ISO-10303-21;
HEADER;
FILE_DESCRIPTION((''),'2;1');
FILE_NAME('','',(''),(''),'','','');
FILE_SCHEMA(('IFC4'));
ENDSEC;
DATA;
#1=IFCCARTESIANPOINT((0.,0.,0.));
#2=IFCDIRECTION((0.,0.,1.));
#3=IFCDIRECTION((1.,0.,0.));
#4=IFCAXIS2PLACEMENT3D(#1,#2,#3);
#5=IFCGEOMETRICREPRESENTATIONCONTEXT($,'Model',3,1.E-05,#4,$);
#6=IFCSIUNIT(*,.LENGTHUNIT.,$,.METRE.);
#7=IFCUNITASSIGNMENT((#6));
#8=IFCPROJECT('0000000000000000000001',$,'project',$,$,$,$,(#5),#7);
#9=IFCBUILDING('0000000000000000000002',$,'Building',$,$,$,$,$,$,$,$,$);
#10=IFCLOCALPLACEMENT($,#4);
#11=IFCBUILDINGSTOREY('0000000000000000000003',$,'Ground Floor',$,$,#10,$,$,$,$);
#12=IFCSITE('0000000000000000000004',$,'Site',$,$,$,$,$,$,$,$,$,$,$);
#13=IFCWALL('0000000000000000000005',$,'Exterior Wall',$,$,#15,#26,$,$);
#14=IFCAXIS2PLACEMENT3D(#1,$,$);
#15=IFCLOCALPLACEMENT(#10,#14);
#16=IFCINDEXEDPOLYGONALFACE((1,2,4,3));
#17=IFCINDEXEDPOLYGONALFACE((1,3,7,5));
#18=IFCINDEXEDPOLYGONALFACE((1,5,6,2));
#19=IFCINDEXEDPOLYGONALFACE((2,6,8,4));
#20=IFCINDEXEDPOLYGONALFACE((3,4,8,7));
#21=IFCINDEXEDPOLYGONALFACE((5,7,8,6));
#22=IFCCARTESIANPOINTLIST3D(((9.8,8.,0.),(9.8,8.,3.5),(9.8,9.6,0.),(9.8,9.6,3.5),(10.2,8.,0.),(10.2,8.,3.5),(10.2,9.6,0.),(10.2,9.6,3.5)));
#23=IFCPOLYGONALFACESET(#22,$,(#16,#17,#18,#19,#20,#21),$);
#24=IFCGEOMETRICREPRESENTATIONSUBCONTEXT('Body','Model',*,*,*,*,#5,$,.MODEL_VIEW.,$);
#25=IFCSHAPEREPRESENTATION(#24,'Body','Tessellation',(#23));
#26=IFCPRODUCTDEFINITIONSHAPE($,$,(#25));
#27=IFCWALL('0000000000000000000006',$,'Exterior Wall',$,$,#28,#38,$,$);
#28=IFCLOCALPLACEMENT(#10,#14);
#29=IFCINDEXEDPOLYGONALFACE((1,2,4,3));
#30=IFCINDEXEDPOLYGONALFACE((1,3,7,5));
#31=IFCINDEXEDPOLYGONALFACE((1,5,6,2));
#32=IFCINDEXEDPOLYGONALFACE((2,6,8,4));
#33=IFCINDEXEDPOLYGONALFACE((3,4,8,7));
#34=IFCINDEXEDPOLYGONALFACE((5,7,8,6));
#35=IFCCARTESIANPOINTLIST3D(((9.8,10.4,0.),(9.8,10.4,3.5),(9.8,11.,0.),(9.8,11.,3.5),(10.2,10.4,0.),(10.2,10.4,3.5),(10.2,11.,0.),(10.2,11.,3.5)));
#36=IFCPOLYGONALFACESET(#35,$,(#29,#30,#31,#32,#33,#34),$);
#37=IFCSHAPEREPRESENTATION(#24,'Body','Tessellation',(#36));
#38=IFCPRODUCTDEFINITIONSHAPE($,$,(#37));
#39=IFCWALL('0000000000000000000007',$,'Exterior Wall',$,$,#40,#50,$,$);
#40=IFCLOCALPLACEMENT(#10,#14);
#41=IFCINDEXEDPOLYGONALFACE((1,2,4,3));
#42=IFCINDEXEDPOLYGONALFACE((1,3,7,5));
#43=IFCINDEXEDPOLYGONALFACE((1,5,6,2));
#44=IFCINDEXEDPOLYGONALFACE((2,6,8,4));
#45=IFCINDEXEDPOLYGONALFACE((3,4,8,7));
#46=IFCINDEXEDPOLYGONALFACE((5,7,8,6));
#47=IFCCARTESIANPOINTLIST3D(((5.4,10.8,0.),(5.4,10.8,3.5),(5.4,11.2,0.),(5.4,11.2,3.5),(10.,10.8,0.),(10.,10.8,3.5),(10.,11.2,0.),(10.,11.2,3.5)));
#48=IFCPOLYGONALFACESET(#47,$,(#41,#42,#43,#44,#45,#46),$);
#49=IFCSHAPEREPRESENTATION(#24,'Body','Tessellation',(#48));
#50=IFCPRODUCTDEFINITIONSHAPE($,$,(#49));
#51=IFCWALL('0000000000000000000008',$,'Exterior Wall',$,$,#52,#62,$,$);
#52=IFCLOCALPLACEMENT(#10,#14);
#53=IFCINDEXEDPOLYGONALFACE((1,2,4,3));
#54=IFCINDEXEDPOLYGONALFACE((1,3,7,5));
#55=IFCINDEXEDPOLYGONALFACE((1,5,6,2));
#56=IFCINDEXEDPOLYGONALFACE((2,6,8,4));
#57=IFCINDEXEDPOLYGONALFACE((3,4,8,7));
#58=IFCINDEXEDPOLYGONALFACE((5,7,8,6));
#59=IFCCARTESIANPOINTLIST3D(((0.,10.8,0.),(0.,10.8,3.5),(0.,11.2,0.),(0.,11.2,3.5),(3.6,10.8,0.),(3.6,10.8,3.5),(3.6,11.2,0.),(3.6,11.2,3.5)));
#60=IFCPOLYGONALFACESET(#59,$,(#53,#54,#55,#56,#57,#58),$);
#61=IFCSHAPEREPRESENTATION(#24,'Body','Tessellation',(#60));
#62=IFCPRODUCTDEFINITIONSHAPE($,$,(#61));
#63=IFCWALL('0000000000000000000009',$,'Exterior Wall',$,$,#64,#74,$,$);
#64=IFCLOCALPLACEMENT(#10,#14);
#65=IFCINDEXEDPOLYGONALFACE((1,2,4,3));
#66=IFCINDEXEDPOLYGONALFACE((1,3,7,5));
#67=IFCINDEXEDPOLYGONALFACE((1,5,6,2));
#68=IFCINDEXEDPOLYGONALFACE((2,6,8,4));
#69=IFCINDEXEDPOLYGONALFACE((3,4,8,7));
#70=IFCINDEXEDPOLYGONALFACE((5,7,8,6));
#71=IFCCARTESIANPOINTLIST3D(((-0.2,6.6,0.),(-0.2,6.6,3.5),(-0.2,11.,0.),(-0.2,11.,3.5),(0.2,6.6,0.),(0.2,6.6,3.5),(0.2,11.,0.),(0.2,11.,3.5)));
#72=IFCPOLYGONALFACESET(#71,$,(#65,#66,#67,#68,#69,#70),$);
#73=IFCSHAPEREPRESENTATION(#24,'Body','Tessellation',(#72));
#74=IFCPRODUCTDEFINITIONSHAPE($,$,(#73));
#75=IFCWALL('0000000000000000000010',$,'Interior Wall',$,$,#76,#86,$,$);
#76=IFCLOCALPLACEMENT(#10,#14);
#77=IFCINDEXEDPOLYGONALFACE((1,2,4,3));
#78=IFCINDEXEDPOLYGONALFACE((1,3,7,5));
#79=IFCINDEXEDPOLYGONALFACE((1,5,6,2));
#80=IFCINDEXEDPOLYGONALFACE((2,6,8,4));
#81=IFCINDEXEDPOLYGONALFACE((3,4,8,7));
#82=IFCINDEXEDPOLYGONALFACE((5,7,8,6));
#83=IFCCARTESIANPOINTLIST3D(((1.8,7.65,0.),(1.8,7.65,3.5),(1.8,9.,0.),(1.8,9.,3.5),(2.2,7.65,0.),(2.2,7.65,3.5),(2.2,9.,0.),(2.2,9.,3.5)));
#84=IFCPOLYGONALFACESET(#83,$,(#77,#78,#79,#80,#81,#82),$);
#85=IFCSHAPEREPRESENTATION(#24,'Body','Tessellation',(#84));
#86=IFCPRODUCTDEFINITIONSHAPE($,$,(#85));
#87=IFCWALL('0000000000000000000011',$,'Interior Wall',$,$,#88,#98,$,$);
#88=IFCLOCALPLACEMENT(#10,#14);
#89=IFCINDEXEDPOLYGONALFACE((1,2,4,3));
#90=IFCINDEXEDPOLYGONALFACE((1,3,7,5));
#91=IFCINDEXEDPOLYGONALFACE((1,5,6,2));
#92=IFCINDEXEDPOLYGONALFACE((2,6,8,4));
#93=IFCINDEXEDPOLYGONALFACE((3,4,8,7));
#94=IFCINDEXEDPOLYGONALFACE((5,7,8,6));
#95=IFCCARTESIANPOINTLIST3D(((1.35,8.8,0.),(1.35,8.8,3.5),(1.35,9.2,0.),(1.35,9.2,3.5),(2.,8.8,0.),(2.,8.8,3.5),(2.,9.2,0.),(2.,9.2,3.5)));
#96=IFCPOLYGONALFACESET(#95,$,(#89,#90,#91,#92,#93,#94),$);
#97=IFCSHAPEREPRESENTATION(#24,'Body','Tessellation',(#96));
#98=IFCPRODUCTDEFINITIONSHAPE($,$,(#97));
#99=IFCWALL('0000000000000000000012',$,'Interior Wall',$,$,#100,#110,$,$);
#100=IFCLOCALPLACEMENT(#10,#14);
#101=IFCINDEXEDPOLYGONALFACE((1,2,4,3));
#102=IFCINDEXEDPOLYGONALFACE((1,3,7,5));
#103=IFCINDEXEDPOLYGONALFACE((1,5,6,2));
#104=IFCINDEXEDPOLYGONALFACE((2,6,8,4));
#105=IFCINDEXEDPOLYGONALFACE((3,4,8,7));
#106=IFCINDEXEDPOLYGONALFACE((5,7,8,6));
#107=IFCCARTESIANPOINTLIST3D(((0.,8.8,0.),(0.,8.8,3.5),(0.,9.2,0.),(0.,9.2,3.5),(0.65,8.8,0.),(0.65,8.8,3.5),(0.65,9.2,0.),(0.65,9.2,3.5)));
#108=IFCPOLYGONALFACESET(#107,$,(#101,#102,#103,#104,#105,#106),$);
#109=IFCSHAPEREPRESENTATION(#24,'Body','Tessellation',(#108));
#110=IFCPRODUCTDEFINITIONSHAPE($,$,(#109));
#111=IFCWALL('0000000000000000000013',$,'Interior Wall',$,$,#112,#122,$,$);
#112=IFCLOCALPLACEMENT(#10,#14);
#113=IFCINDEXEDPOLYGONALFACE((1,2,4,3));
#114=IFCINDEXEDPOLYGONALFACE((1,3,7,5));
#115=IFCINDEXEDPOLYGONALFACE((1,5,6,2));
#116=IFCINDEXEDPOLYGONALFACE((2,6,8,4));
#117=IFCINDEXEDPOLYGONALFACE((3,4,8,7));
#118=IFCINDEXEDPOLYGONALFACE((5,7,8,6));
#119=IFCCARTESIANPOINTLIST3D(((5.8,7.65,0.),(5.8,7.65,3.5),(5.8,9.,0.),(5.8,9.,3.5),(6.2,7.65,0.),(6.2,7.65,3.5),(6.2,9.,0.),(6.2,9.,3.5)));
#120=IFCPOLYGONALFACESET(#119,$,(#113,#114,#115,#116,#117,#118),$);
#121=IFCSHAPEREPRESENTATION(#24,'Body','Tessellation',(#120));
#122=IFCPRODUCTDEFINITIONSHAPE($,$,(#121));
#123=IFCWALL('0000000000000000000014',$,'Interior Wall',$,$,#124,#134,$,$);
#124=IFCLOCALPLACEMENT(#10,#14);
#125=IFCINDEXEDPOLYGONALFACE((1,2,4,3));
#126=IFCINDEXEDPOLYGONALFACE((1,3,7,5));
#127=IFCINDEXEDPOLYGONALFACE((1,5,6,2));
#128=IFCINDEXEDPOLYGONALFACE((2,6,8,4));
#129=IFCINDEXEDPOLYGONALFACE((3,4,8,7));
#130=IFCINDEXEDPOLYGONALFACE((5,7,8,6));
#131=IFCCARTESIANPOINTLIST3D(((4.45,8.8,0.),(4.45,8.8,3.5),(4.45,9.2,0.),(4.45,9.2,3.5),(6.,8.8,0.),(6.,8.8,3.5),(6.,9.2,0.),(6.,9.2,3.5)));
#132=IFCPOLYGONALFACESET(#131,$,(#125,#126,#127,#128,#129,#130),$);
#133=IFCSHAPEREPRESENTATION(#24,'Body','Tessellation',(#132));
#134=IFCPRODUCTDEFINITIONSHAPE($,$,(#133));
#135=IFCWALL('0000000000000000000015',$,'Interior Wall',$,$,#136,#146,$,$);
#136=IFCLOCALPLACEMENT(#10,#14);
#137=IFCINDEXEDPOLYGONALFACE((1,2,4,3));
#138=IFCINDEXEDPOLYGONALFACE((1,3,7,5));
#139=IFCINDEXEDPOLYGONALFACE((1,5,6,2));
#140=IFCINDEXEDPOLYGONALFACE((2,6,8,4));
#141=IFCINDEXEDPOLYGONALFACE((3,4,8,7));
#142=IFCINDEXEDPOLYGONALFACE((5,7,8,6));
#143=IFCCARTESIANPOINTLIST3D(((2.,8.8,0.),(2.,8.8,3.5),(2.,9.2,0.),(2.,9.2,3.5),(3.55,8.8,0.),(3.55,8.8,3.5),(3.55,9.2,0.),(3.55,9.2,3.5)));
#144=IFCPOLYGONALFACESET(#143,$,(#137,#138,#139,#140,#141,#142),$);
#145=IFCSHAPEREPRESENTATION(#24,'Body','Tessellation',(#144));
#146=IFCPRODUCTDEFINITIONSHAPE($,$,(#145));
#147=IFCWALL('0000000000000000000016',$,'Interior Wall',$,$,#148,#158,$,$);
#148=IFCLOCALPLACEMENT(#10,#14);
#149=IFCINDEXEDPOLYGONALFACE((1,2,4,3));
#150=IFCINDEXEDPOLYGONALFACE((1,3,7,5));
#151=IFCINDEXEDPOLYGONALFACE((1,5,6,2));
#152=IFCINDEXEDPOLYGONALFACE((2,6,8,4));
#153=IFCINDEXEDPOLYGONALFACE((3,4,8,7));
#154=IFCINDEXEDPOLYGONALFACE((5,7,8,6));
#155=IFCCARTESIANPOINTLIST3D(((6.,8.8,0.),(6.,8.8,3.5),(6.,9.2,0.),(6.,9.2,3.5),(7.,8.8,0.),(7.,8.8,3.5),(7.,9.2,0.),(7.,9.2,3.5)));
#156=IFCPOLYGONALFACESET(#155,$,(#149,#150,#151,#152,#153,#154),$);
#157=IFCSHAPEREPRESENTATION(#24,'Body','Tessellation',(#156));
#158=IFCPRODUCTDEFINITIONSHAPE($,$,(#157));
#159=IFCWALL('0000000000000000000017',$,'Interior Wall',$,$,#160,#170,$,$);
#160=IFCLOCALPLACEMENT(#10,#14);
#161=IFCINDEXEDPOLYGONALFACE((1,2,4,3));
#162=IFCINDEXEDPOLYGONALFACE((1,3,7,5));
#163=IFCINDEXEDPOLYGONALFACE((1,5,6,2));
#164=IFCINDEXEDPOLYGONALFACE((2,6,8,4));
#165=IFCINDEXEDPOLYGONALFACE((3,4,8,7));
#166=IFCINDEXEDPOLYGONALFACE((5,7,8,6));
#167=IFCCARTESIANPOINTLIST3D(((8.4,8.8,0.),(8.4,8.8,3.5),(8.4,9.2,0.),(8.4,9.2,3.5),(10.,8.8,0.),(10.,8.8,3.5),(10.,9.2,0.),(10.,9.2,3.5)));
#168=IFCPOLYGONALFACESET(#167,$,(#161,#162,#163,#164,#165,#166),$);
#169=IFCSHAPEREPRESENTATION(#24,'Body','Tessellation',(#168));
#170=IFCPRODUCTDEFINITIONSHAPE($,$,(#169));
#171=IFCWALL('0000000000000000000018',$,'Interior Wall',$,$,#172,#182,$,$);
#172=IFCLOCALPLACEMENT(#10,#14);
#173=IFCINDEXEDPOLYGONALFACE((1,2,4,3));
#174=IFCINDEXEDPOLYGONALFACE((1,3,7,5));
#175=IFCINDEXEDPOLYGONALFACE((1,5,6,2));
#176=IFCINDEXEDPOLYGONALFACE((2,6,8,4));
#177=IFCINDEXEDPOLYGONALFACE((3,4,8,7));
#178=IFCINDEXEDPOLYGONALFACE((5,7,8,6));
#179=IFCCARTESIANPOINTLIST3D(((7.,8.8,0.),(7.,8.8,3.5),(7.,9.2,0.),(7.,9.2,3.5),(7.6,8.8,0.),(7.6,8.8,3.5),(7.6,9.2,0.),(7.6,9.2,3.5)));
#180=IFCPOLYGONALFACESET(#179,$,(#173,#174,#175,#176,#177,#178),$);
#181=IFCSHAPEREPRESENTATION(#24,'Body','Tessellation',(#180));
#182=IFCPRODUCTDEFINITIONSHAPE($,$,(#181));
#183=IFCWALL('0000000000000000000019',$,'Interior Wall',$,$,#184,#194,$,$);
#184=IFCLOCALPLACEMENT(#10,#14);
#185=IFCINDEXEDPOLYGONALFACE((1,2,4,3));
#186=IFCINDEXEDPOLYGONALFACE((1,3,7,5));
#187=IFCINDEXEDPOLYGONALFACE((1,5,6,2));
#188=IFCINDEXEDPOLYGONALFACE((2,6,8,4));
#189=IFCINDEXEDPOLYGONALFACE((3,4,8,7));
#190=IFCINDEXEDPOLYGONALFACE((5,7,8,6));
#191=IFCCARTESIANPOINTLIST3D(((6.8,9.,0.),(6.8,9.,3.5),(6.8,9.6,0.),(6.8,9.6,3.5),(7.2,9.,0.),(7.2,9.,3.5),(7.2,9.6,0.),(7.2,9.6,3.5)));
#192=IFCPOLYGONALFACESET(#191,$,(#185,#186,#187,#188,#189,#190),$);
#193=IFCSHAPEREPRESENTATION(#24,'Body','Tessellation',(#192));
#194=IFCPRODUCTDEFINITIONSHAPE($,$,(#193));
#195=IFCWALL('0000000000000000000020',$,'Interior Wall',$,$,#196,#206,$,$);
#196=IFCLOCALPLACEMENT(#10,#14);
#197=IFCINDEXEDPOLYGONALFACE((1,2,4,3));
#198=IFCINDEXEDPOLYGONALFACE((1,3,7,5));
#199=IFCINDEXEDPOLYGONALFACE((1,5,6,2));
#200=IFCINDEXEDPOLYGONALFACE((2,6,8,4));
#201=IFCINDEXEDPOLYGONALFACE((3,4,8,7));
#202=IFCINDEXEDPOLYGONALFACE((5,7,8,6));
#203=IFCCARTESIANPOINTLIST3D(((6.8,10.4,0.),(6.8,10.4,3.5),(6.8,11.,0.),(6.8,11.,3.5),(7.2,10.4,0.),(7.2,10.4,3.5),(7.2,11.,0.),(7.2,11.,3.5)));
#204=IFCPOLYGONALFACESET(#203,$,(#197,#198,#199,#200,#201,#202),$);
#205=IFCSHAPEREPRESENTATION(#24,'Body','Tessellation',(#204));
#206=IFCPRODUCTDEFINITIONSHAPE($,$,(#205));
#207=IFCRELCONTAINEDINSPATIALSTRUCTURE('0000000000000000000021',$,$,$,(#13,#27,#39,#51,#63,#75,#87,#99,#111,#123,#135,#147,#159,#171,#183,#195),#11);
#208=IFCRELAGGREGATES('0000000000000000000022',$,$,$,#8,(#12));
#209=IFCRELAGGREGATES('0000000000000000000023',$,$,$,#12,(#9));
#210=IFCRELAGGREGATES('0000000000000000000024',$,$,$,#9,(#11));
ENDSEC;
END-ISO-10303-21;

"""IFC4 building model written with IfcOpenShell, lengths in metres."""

from ifc_helpers import new_model, si_unit, frame, origin_with_axes, place, context, subcontext, project, spatial, indexed_curve, outline, extrude, element, save


model = new_model("IFC4")

# Units and contexts
model_context = context("Model", 3, precision=1e-05, world=origin_with_axes())
body_context = subcontext(model_context, "Body", "Model", "MODEL_VIEW")
ifc_project = project(units=[si_unit("LENGTHUNIT", "METRE")], contexts=[model_context])

# Site, building, storey
site = spatial("IfcSite", under=ifc_project, Name="Site")
building = spatial("IfcBuilding", under=site, Name="Building")
storey_placement = place(None, origin_with_axes())
storey = spatial("IfcBuildingStorey", under=building, at=storey_placement, Name="Ground Floor")

# Walls
wall_1_placement = place(storey_placement, frame((10.0, 8.0, 0.0), z_axis=(0.0, 0.0, 1.0), x_axis=(0.0, 1.0, 0.0)))
element("IfcWall", 1, at=wall_1_placement, inside=storey, Name="Exterior Wall", context=body_context, shape_type="SweptSolid", body=[
    extrude(outline(indexed_curve([(0.0, 0.0), (0.0, 0.4), (1.6, 0.4), (1.6, 0.0), (0.0, 0.0)], self_intersect=False)), frame((0.0, -0.2, 0.0), z_axis=(0.0, 0.0, 1.0), x_axis=(1.0, 0.0, 0.0)), (0.0, 0.0, 1.0), 3.5),
])
wall_2_placement = place(storey_placement, frame((10.0, 10.4, 0.0), z_axis=(0.0, 0.0, 1.0), x_axis=(0.0, 1.0, 0.0)))
element("IfcWall", 2, at=wall_2_placement, inside=storey, Name="Exterior Wall", context=body_context, shape_type="SweptSolid", body=[
    extrude(outline(indexed_curve([(0.0, 0.0), (0.0, 0.4), (0.6, 0.4), (0.6, 0.0), (0.0, 0.0)], self_intersect=False)), frame((0.0, -0.2, 0.0), z_axis=(0.0, 0.0, 1.0), x_axis=(1.0, 0.0, 0.0)), (0.0, 0.0, 1.0), 3.5),
])
wall_3_placement = place(storey_placement, frame((10.0, 11.0, 0.0), z_axis=(0.0, 0.0, 1.0), x_axis=(-1.0, 0.0, 0.0)))
element("IfcWall", 3, at=wall_3_placement, inside=storey, Name="Exterior Wall", context=body_context, shape_type="SweptSolid", body=[
    extrude(outline(indexed_curve([(0.0, 0.0), (0.0, 0.4), (4.6, 0.4), (4.6, 0.0), (0.0, 0.0)], self_intersect=False)), frame((0.0, -0.2, 0.0), z_axis=(0.0, 0.0, 1.0), x_axis=(1.0, 0.0, 0.0)), (0.0, 0.0, 1.0), 3.5),
])
wall_4_placement = place(storey_placement, frame((3.6, 11.0, 0.0), z_axis=(0.0, 0.0, 1.0), x_axis=(-1.0, 0.0, 0.0)))
element("IfcWall", 4, at=wall_4_placement, inside=storey, Name="Exterior Wall", context=body_context, shape_type="SweptSolid", body=[
    extrude(outline(indexed_curve([(0.0, 0.0), (0.0, 0.4), (3.6, 0.4), (3.6, 0.0), (0.0, 0.0)], self_intersect=False)), frame((0.0, -0.2, 0.0), z_axis=(0.0, 0.0, 1.0), x_axis=(1.0, 0.0, 0.0)), (0.0, 0.0, 1.0), 3.5),
])
wall_5_placement = place(storey_placement, frame((0.0, 11.0, 0.0), z_axis=(0.0, 0.0, 1.0), x_axis=(0.0, -1.0, 0.0)))
element("IfcWall", 5, at=wall_5_placement, inside=storey, Name="Exterior Wall", context=body_context, shape_type="SweptSolid", body=[
    extrude(outline(indexed_curve([(0.0, 0.0), (0.0, 0.4), (4.4, 0.4), (4.4, 0.0), (0.0, 0.0)], self_intersect=False)), frame((0.0, -0.2, 0.0), z_axis=(0.0, 0.0, 1.0), x_axis=(1.0, 0.0, 0.0)), (0.0, 0.0, 1.0), 3.5),
])
wall_6_placement = place(storey_placement, frame((2.0, 7.65, 0.0), z_axis=(0.0, 0.0, 1.0), x_axis=(0.0, 1.0, 0.0)))
element("IfcWall", 6, at=wall_6_placement, inside=storey, Name="Interior Wall", context=body_context, shape_type="SweptSolid", body=[
    extrude(outline(indexed_curve([(0.0, 0.0), (0.0, 0.4), (1.35, 0.4), (1.35, 0.0), (0.0, 0.0)], self_intersect=False)), frame((0.0, -0.2, 0.0), z_axis=(0.0, 0.0, 1.0), x_axis=(1.0, 0.0, 0.0)), (0.0, 0.0, 1.0), 3.5),
])
for number, where, z_axis, x_axis, name in (
    (7, (2.0, 9.0, 0.0), (0.0, 0.0, 1.0), (-1.0, 0.0, 0.0), "Interior Wall"),
    (8, (0.65, 9.0, 0.0), (0.0, 0.0, 1.0), (-1.0, 0.0, 0.0), "Interior Wall"),
):
    element("IfcWall", number, at=place(storey_placement, frame(where, z_axis=z_axis, x_axis=x_axis)), inside=storey, Name=name, context=body_context, shape_type="SweptSolid", body=[
        extrude(outline(indexed_curve([(0.0, 0.0), (0.0, 0.4), (0.65, 0.4), (0.65, 0.0), (0.0, 0.0)], self_intersect=False)), frame((0.0, -0.2, 0.0), z_axis=(0.0, 0.0, 1.0), x_axis=(1.0, 0.0, 0.0)), (0.0, 0.0, 1.0), 3.5),
    ])
wall_7_placement = place(storey_placement, frame((6.0, 7.65, 0.0), z_axis=(0.0, 0.0, 1.0), x_axis=(0.0, 1.0, 0.0)))
element("IfcWall", 9, at=wall_7_placement, inside=storey, Name="Interior Wall", context=body_context, shape_type="SweptSolid", body=[
    extrude(outline(indexed_curve([(0.0, 0.0), (0.0, 0.4), (1.35, 0.4), (1.35, 0.0), (0.0, 0.0)], self_intersect=False)), frame((0.0, -0.2, 0.0), z_axis=(0.0, 0.0, 1.0), x_axis=(1.0, 0.0, 0.0)), (0.0, 0.0, 1.0), 3.5),
])
for number, where, z_axis, x_axis, name in (
    (10, (6.0, 9.0, 0.0), (0.0, 0.0, 1.0), (-1.0, 0.0, 0.0), "Interior Wall"),
    (11, (3.55, 9.0, 0.0), (0.0, 0.0, 1.0), (-1.0, 0.0, 0.0), "Interior Wall"),
):
    element("IfcWall", number, at=place(storey_placement, frame(where, z_axis=z_axis, x_axis=x_axis)), inside=storey, Name=name, context=body_context, shape_type="SweptSolid", body=[
        extrude(outline(indexed_curve([(0.0, 0.0), (0.0, 0.4), (1.55, 0.4), (1.55, 0.0), (0.0, 0.0)], self_intersect=False)), frame((0.0, -0.2, 0.0), z_axis=(0.0, 0.0, 1.0), x_axis=(1.0, 0.0, 0.0)), (0.0, 0.0, 1.0), 3.5),
    ])
wall_8_placement = place(storey_placement, frame((7.0, 9.0, 0.0), z_axis=(0.0, 0.0, 1.0), x_axis=(-1.0, 0.0, 0.0)))
element("IfcWall", 12, at=wall_8_placement, inside=storey, Name="Interior Wall", context=body_context, shape_type="SweptSolid", body=[
    extrude(outline(indexed_curve([(0.0, 0.0), (0.0, 0.4), (1.0, 0.4), (1.0, 0.0), (0.0, 0.0)], self_intersect=False)), frame((0.0, -0.2, 0.0), z_axis=(0.0, 0.0, 1.0), x_axis=(1.0, 0.0, 0.0)), (0.0, 0.0, 1.0), 3.5),
])
wall_9_placement = place(storey_placement, frame((10.0, 9.0, 0.0), z_axis=(0.0, 0.0, 1.0), x_axis=(-1.0, 0.0, 0.0)))
element("IfcWall", 13, at=wall_9_placement, inside=storey, Name="Interior Wall", context=body_context, shape_type="SweptSolid", body=[
    extrude(outline(indexed_curve([(0.0, 0.0), (0.0, 0.4), (1.6, 0.4), (1.6, 0.0), (0.0, 0.0)], self_intersect=False)), frame((0.0, -0.2, 0.0), z_axis=(0.0, 0.0, 1.0), x_axis=(1.0, 0.0, 0.0)), (0.0, 0.0, 1.0), 3.5),
])
for number, where, z_axis, x_axis, name in (
    (14, (7.6, 9.0, 0.0), (0.0, 0.0, 1.0), (-1.0, 0.0, 0.0), "Interior Wall"),
    (15, (7.0, 9.0, 0.0), (0.0, 0.0, 1.0), (0.0, 1.0, 0.0), "Interior Wall"),
    (16, (7.0, 10.4, 0.0), (0.0, 0.0, 1.0), (0.0, 1.0, 0.0), "Interior Wall"),
):
    element("IfcWall", number, at=place(storey_placement, frame(where, z_axis=z_axis, x_axis=x_axis)), inside=storey, Name=name, context=body_context, shape_type="SweptSolid", body=[
        extrude(outline(indexed_curve([(0.0, 0.0), (0.0, 0.4), (0.6, 0.4), (0.6, 0.0), (0.0, 0.0)], self_intersect=False)), frame((0.0, -0.2, 0.0), z_axis=(0.0, 0.0, 1.0), x_axis=(1.0, 0.0, 0.0)), (0.0, 0.0, 1.0), 3.5),
    ])

save(model, "model.ifc")
